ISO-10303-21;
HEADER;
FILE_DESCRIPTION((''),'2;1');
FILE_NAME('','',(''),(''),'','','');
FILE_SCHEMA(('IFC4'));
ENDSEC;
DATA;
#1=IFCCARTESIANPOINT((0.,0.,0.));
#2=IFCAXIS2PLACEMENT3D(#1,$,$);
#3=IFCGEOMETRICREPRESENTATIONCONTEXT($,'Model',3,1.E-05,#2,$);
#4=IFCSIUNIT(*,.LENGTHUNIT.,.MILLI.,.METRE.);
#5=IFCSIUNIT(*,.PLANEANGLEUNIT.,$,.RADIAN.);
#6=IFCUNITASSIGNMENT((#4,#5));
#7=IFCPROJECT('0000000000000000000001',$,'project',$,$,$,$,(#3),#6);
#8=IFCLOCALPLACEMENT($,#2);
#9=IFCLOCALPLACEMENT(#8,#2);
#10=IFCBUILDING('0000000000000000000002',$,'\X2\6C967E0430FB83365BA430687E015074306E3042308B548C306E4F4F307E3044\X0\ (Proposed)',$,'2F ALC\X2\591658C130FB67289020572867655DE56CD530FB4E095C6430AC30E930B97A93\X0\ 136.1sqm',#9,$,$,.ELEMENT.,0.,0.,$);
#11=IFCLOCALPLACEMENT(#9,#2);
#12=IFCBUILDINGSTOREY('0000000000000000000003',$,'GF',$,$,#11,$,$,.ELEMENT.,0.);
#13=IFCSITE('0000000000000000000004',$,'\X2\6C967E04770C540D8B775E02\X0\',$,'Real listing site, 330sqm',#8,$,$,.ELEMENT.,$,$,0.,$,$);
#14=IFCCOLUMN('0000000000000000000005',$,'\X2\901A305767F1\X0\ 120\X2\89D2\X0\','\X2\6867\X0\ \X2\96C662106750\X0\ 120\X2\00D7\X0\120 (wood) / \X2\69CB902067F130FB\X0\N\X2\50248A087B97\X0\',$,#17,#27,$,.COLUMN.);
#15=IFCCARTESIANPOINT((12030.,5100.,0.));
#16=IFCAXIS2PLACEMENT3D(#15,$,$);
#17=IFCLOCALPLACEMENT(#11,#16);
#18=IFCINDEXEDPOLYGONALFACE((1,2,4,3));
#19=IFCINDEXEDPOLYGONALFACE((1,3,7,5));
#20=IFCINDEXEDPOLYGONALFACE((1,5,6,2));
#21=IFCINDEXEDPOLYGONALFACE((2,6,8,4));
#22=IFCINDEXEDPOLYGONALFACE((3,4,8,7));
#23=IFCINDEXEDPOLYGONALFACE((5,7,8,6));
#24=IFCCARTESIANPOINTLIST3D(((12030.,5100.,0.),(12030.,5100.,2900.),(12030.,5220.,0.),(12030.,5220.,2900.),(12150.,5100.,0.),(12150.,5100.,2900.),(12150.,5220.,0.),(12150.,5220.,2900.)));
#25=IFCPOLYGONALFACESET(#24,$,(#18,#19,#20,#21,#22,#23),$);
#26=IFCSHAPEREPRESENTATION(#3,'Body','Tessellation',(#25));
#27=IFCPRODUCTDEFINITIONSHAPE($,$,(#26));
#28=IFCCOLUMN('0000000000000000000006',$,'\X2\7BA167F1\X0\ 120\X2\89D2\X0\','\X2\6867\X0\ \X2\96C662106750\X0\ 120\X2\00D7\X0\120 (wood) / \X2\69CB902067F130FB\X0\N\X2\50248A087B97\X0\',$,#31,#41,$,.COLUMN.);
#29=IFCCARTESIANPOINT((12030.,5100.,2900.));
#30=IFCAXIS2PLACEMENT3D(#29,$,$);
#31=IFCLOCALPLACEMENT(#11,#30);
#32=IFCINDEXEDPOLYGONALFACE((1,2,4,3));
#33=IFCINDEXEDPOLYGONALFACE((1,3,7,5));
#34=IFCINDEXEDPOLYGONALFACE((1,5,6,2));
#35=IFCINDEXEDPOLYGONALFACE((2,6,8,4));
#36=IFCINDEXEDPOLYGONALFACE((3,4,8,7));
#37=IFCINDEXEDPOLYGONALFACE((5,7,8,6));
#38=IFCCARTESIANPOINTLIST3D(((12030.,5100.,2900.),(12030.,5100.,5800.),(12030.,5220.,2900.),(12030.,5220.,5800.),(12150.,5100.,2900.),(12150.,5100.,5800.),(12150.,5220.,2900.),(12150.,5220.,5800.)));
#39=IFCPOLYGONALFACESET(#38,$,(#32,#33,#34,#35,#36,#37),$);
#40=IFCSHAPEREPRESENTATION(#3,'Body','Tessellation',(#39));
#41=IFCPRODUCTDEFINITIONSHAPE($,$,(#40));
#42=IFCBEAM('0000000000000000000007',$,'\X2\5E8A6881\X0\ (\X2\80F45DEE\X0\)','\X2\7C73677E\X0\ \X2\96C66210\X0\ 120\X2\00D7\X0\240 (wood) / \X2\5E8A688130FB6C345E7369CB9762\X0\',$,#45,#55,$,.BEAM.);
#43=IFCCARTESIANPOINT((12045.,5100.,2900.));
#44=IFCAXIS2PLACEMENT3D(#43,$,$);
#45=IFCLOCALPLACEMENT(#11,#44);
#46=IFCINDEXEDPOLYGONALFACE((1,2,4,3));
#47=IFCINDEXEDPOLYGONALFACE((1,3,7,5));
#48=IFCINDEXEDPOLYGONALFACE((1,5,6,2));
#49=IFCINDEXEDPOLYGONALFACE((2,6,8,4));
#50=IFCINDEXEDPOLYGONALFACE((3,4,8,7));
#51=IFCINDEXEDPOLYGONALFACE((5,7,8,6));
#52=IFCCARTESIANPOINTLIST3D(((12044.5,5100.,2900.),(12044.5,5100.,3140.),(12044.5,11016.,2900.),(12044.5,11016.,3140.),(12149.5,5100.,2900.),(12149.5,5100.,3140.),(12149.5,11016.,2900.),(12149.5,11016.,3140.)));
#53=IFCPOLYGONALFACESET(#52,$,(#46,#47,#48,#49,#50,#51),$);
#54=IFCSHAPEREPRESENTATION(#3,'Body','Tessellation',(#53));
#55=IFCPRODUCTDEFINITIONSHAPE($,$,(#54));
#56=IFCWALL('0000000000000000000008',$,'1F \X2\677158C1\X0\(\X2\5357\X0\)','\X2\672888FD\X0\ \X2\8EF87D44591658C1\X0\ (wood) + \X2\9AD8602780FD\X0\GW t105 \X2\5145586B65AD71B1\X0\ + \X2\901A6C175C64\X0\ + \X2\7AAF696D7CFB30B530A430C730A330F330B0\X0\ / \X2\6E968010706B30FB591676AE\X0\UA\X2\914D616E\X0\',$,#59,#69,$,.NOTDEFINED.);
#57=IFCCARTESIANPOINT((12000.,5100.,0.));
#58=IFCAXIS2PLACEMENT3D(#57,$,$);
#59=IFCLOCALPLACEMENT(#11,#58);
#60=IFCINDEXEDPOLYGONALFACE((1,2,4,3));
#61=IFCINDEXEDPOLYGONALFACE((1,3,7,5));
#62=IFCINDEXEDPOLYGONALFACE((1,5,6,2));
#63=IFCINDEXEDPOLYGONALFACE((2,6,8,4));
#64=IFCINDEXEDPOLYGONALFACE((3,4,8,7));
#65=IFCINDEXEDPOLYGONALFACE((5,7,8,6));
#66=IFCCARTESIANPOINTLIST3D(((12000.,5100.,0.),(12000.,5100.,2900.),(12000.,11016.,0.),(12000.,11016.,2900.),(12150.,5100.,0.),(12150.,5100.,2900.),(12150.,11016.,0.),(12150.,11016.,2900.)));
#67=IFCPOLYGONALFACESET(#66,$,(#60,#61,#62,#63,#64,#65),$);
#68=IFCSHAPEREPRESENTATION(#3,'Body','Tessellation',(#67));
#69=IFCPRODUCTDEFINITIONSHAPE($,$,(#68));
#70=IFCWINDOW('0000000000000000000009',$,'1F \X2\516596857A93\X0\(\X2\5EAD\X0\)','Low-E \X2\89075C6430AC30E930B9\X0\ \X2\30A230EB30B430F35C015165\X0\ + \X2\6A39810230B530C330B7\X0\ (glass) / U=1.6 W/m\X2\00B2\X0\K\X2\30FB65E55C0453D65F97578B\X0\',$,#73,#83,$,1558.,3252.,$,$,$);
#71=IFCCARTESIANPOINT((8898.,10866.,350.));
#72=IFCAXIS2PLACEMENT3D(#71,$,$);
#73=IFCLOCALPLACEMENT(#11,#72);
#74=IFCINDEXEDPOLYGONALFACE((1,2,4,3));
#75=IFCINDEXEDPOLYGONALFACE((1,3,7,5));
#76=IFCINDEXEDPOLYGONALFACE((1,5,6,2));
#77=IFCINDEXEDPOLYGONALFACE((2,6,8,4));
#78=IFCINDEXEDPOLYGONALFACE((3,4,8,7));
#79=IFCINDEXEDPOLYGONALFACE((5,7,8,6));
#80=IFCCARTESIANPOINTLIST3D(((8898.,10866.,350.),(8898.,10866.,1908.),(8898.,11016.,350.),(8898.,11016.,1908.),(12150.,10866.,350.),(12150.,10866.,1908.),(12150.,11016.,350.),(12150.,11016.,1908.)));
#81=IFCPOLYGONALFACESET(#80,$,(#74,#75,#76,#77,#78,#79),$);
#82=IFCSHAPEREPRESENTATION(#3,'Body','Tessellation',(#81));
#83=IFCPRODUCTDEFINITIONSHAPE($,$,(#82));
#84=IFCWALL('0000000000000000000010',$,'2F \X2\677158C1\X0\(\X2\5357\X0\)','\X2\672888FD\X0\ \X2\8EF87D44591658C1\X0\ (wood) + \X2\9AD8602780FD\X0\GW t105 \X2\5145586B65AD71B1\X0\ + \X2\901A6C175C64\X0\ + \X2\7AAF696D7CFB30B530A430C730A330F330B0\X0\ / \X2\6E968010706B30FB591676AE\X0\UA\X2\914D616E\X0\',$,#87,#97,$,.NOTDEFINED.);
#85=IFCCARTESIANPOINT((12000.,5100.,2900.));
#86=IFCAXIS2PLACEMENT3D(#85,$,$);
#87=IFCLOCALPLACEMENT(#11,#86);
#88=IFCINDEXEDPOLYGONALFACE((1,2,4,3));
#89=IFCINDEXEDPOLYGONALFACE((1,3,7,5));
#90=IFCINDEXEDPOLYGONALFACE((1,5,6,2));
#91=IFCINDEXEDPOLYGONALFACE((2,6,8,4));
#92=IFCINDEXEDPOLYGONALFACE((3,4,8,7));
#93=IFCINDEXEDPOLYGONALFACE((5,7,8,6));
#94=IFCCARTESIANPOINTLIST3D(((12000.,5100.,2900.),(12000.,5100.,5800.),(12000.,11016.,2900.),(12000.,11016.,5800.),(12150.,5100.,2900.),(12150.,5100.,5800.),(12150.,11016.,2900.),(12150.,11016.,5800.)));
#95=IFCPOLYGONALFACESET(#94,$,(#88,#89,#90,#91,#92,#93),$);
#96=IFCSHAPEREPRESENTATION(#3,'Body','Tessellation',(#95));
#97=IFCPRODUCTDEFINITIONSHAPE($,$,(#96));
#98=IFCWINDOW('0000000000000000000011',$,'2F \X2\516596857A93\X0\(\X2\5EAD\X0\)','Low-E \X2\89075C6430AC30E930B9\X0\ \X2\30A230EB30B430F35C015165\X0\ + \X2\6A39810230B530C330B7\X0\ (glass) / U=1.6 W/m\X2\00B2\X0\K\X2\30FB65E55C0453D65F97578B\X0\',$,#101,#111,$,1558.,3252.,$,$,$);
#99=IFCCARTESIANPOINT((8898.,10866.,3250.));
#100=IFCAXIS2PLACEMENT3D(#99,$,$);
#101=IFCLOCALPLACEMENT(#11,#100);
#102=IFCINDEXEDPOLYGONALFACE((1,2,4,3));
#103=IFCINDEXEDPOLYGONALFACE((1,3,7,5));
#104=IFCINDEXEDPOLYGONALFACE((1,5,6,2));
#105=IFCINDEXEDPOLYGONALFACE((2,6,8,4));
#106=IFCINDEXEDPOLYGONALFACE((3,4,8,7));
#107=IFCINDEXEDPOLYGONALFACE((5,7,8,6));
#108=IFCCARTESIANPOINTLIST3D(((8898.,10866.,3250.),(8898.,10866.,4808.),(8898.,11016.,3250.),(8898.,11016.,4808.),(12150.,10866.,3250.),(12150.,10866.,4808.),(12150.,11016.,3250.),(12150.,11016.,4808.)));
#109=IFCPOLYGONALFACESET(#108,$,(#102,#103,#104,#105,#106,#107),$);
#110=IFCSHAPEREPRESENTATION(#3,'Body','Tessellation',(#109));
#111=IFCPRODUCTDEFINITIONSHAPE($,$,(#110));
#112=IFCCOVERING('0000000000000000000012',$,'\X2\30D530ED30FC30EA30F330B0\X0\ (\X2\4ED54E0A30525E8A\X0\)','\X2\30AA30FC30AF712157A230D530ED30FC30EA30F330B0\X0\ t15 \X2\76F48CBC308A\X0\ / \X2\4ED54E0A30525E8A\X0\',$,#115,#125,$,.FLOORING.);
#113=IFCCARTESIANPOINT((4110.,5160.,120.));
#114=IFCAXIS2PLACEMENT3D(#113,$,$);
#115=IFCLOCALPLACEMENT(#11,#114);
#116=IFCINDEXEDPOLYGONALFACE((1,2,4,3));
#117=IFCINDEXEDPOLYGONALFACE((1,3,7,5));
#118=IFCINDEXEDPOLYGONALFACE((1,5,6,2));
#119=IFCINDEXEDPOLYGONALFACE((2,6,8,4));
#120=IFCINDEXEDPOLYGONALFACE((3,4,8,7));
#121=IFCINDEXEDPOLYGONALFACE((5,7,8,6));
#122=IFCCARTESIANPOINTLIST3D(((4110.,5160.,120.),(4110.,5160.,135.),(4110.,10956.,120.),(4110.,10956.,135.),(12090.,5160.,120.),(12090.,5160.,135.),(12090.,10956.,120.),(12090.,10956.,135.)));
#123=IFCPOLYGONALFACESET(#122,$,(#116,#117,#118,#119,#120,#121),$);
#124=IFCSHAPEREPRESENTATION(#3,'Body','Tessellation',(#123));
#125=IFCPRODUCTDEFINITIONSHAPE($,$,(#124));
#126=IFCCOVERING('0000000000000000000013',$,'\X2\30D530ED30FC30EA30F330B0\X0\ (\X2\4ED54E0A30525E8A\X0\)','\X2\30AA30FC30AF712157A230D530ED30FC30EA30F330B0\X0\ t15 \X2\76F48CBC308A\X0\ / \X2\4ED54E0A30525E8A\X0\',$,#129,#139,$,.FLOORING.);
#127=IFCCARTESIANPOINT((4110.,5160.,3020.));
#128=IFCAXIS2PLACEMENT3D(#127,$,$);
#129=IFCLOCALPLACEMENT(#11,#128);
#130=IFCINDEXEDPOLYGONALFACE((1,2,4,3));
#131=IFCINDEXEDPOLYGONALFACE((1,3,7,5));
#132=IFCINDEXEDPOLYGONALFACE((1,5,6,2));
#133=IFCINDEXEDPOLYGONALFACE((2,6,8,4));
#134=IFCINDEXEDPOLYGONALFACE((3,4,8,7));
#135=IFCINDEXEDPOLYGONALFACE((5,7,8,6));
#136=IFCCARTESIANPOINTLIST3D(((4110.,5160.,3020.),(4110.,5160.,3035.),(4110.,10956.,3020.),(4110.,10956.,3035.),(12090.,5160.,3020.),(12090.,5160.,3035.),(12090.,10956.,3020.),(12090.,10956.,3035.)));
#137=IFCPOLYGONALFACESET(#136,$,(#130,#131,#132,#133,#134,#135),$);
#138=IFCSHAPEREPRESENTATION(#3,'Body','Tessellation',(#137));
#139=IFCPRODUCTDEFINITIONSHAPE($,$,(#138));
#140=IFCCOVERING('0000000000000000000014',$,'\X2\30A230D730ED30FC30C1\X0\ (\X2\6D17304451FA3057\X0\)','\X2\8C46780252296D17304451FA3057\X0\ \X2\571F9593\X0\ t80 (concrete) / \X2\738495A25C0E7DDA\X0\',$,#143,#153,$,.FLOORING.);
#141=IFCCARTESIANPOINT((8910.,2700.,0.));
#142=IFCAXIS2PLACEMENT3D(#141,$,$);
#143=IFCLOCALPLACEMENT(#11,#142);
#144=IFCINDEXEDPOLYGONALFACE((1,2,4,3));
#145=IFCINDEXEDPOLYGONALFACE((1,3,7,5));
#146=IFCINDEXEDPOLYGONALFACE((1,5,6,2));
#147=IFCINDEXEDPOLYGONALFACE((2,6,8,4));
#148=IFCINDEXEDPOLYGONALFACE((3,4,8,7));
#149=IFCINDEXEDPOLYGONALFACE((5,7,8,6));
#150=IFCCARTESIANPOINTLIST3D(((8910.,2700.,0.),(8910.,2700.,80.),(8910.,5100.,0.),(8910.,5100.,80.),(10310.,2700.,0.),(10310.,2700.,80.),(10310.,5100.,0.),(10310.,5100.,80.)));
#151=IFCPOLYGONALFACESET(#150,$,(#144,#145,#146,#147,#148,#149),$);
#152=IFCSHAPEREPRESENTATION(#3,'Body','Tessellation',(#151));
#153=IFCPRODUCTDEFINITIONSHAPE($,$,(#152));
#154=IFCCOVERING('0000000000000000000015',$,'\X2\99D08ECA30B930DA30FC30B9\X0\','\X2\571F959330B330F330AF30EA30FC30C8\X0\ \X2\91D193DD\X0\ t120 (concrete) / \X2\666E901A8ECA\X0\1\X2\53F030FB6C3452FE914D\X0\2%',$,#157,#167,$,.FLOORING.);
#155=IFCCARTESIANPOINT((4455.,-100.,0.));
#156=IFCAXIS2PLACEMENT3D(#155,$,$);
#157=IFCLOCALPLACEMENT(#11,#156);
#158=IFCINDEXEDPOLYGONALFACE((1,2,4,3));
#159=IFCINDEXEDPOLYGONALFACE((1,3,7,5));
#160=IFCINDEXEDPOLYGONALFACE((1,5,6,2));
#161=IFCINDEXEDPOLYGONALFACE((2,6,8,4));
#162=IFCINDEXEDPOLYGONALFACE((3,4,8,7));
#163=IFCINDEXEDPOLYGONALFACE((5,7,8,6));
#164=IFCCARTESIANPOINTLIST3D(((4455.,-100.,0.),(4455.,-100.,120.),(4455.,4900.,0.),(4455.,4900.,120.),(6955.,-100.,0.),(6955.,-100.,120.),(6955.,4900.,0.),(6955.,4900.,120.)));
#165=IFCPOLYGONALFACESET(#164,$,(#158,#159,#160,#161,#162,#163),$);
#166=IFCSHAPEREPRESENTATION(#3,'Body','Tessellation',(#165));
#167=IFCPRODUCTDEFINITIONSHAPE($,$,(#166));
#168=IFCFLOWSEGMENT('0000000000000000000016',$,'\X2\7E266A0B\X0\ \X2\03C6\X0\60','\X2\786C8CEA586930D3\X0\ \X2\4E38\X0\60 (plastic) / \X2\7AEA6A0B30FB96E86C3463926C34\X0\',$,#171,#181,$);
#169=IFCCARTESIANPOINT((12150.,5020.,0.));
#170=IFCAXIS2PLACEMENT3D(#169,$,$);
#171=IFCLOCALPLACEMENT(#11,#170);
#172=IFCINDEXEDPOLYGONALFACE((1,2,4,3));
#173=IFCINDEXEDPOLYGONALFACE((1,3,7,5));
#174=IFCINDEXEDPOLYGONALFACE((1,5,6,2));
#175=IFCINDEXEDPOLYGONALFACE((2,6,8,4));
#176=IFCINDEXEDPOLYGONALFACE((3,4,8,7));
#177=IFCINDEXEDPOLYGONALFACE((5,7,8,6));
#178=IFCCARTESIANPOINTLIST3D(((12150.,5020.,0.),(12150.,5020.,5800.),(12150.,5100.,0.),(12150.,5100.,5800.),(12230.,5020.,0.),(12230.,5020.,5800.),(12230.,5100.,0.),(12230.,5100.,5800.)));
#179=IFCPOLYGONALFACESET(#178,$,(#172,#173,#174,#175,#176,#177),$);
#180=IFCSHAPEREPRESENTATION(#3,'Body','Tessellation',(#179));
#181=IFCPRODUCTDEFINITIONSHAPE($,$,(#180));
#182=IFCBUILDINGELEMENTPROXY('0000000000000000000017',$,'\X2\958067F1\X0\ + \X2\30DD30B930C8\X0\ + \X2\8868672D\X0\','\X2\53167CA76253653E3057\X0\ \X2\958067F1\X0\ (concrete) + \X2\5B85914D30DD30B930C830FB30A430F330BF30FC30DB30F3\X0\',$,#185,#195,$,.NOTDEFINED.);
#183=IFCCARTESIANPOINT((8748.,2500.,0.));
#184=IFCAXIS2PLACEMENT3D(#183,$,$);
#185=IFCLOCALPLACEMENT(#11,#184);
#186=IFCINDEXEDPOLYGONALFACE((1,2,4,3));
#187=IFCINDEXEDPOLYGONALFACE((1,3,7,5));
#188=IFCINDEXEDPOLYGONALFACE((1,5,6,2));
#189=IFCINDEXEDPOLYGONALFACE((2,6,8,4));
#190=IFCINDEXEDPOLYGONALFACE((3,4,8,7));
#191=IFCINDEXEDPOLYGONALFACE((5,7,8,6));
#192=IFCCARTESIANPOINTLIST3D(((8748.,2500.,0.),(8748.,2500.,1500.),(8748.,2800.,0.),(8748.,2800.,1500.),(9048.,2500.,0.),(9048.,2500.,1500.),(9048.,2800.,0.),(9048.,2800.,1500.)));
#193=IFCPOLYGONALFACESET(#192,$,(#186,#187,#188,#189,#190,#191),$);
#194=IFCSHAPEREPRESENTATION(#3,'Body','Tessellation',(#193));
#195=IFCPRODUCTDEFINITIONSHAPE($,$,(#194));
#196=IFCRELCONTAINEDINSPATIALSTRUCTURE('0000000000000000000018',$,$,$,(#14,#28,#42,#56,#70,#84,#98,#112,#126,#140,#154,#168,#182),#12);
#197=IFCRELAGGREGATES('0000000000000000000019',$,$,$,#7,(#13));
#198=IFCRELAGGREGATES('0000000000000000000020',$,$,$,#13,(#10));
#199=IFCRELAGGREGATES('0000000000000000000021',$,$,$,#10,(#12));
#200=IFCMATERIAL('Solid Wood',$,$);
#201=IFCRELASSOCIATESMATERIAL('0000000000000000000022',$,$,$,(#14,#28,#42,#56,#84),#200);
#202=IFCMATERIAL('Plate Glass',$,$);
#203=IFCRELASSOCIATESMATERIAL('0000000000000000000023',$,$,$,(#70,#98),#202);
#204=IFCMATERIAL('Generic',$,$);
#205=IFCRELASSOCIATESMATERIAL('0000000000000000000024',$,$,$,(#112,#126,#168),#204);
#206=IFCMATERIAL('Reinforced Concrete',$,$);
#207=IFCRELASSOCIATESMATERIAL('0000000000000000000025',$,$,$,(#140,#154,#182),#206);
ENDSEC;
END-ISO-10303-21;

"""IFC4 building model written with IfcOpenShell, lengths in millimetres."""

from ifc_helpers import new_model, si_unit, frame, frame_2d, origin, place, context, project, spatial, rectangle, extrude, material, element, fill, save


model = new_model("IFC4")

# Units and contexts
model_context = context("Model", 3, precision=1e-05, world=origin())
ifc_project = project(units=[si_unit("LENGTHUNIT", "METRE", prefix="MILLI"), si_unit("PLANEANGLEUNIT", "RADIAN")], contexts=[model_context])

# Site, building, storey
site_placement = place(None, origin())
site = spatial("IfcSite", under=ifc_project, at=site_placement, Name="沖縄県名護市", ObjectType="Real listing site, 330sqm", CompositionType="ELEMENT", RefElevation=0.0)
building_placement = place(site_placement, origin())
building = spatial("IfcBuilding", under=site, at=building_placement, Name="沖縄・茶室と縁側のある和の住まい (Proposed)", ObjectType="2F ALC外壁・木造在来工法・三層ガラス窓 136.1sqm", CompositionType="ELEMENT", ElevationOfRefHeight=0.0, ElevationOfTerrain=0.0)
storey_placement = place(building_placement, origin())
storey = spatial("IfcBuildingStorey", under=building, at=storey_placement, Name="GF", CompositionType="ELEMENT", Elevation=0.0)

# Columns
ifc_material_1 = material(Name="Solid Wood")
column_1_placement = place(storey_placement, frame((12030.0, 5100.0, 0.0)))
element("IfcColumn", 1, at=column_1_placement, inside=storey, material=ifc_material_1, Name="通し柱 120角", Description="桧 集成材 120×120 (wood) / 構造柱・N値計算", PredefinedType="COLUMN", context=model_context, shape_type="SweptSolid", body=[
    extrude(rectangle(XDim=120.0, YDim=120.0, at=frame_2d((60.0, 60.0))), frame((12030.0, 5100.0, 0.0)), (0.0, 0.0, 1.0), 2900.0),
])
column_2_placement = place(storey_placement, frame((12030.0, 5100.0, 2900.0)))
element("IfcColumn", 2, at=column_2_placement, inside=storey, material=ifc_material_1, Name="管柱 120角", Description="桧 集成材 120×120 (wood) / 構造柱・N値計算", PredefinedType="COLUMN", context=model_context, shape_type="SweptSolid", body=[
    extrude(rectangle(XDim=120.0, YDim=120.0, at=frame_2d((60.0, 60.0))), frame((12030.0, 5100.0, 2900.0)), (0.0, 0.0, 1.0), 2900.0),
])

# Beam
beam_1_placement = place(storey_placement, frame((12045.0, 5100.0, 2900.0)))
element("IfcBeam", 3, at=beam_1_placement, inside=storey, material=ifc_material_1, Name="床梁 (胴差)", Description="米松 集成 120×240 (wood) / 床梁・水平構面", PredefinedType="BEAM", context=model_context, shape_type="SweptSolid", body=[
    extrude(rectangle(XDim=105.0, YDim=5916.0, at=frame_2d((52.0, 2958.0))), frame((12045.0, 5100.0, 2900.0)), (0.0, 0.0, 1.0), 240.0),
])

# Wall, opening, window
wall_1_placement = place(storey_placement, frame((12000.0, 5100.0, 0.0)))
wall_1 = element("IfcWall", 4, at=wall_1_placement, inside=storey, material=ifc_material_1, Name="1F 東壁(南)", Description="木製 軸組外壁 (wood) + 高性能GW t105 充填断熱 + 通気層 + 窯業系サイディング / 準耐火・外皮UA配慮", PredefinedType="NOTDEFINED", context=model_context, shape_type="SweptSolid", body=[
    extrude(rectangle(XDim=150.0, YDim=5916.0, at=frame_2d((75.0, 2958.0))), frame((12000.0, 5100.0, 0.0)), (0.0, 0.0, 1.0), 2900.0),
])
opening_1_placement = place(storey_placement, frame((8898.0, 10866.0, 350.0)))
opening_1 = element("IfcOpeningElement", 5, at=opening_1_placement, cuts=wall_1, PredefinedType="NOTDEFINED", context=model_context, shape_type="SweptSolid", body=[
    extrude(rectangle(XDim=3252.0, YDim=150.0, at=frame_2d((1626.0, 75.0))), frame((8898.0, 10866.0, 350.0)), (0.0, 0.0, 1.0), 1558.0),
])
ifc_material_2 = material(Name="Plate Glass")
window_1_placement = place(storey_placement, frame((8898.0, 10866.0, 350.0)))
window_1 = element("IfcWindow", 6, at=window_1_placement, inside=storey, material=ifc_material_2, Name="1F 入隅窓(庭)", Description="Low-E 複層ガラス アルゴン封入 + 樹脂サッシ (glass) / U=1.6 W/m²K・日射取得型", OverallHeight=1558.0, OverallWidth=3252.0, context=model_context, shape_type="SweptSolid", body=[
    extrude(rectangle(XDim=3252.0, YDim=150.0, at=frame_2d((1626.0, 75.0))), frame((8898.0, 10866.0, 350.0)), (0.0, 0.0, 1.0), 1558.0),
])
fill(opening_1, window_1)

# Wall, opening, window
wall_2_placement = place(storey_placement, frame((12000.0, 5100.0, 2900.0)))
wall_2 = element("IfcWall", 7, at=wall_2_placement, inside=storey, material=ifc_material_1, Name="2F 東壁(南)", Description="木製 軸組外壁 (wood) + 高性能GW t105 充填断熱 + 通気層 + 窯業系サイディング / 準耐火・外皮UA配慮", PredefinedType="NOTDEFINED", context=model_context, shape_type="SweptSolid", body=[
    extrude(rectangle(XDim=150.0, YDim=5916.0, at=frame_2d((75.0, 2958.0))), frame((12000.0, 5100.0, 2900.0)), (0.0, 0.0, 1.0), 2900.0),
])
opening_2_placement = place(storey_placement, frame((8898.0, 10866.0, 3250.0)))
opening_2 = element("IfcOpeningElement", 8, at=opening_2_placement, cuts=wall_2, PredefinedType="NOTDEFINED", context=model_context, shape_type="SweptSolid", body=[
    extrude(rectangle(XDim=3252.0, YDim=150.0, at=frame_2d((1626.0, 75.0))), frame((8898.0, 10866.0, 3250.0)), (0.0, 0.0, 1.0), 1558.0),
])
window_2_placement = place(storey_placement, frame((8898.0, 10866.0, 3250.0)))
window_2 = element("IfcWindow", 9, at=window_2_placement, inside=storey, material=ifc_material_2, Name="2F 入隅窓(庭)", Description="Low-E 複層ガラス アルゴン封入 + 樹脂サッシ (glass) / U=1.6 W/m²K・日射取得型", OverallHeight=1558.0, OverallWidth=3252.0, context=model_context, shape_type="SweptSolid", body=[
    extrude(rectangle(XDim=3252.0, YDim=150.0, at=frame_2d((1626.0, 75.0))), frame((8898.0, 10866.0, 3250.0)), (0.0, 0.0, 1.0), 1558.0),
])
fill(opening_2, window_2)

# Coverings
ifc_material_3 = material(Name="Generic")
covering_1_placement = place(storey_placement, frame((4110.0, 5160.0, 120.0)))
element("IfcCovering", 10, at=covering_1_placement, inside=storey, material=ifc_material_3, Name="フローリング (仕上げ床)", Description="オーク無垢フローリング t15 直貼り / 仕上げ床", PredefinedType="FLOORING", context=model_context, shape_type="SweptSolid", body=[
    extrude(rectangle(XDim=7980.0, YDim=5796.0, at=frame_2d((3990.0, 2898.0))), frame((4110.0, 5160.0, 120.0)), (0.0, 0.0, 1.0), 15.0),
])
covering_2_placement = place(storey_placement, frame((4110.0, 5160.0, 3020.0)))
element("IfcCovering", 11, at=covering_2_placement, inside=storey, material=ifc_material_3, Name="フローリング (仕上げ床)", Description="オーク無垢フローリング t15 直貼り / 仕上げ床", PredefinedType="FLOORING", context=model_context, shape_type="SweptSolid", body=[
    extrude(rectangle(XDim=7980.0, YDim=5796.0, at=frame_2d((3990.0, 2898.0))), frame((4110.0, 5160.0, 3020.0)), (0.0, 0.0, 1.0), 15.0),
])
ifc_material_4 = material(Name="Reinforced Concrete")
covering_3_placement = place(storey_placement, frame((8910.0, 2700.0, 0.0)))
element("IfcCovering", 12, at=covering_3_placement, inside=storey, material=ifc_material_4, Name="アプローチ (洗い出し)", Description="豆砂利洗い出し 土間 t80 (concrete) / 玄関導線", PredefinedType="FLOORING", context=model_context, shape_type="SweptSolid", body=[
    extrude(rectangle(XDim=1400.0, YDim=2400.0, at=frame_2d((700.0, 1200.0))), frame((8910.0, 2700.0, 0.0)), (0.0, 0.0, 1.0), 80.0),
])
covering_4_placement = place(storey_placement, frame((4455.0, -100.0, 0.0)))
element("IfcCovering", 13, at=covering_4_placement, inside=storey, material=ifc_material_4, Name="駐車スペース", Description="土間コンクリート 金鏝 t120 (concrete) / 普通車1台・水勾配2%", PredefinedType="FLOORING", context=model_context, shape_type="SweptSolid", body=[
    extrude(rectangle(XDim=2500.0, YDim=5000.0, at=frame_2d((1250.0, 2500.0))), frame((4455.0, -100.0, 0.0)), (0.0, 0.0, 1.0), 120.0),
])

# Flow segment
flow_segment_placement = place(storey_placement, frame((12150.0, 5020.0, 0.0)))
element("IfcFlowSegment", 14, at=flow_segment_placement, inside=storey, material=ifc_material_3, Name="縦樋 φ60", Description="硬質塩ビ 丸60 (plastic) / 竪樋・雨水排水", context=model_context, shape_type="SweptSolid", body=[
    extrude(rectangle(XDim=80.0, YDim=80.0, at=frame_2d((40.0, 40.0))), frame((12150.0, 5020.0, 0.0)), (0.0, 0.0, 1.0), 5800.0),
])

# Building element proxy
proxy_placement = place(storey_placement, frame((8748.0, 2500.0, 0.0)))
element("IfcBuildingElementProxy", 15, at=proxy_placement, inside=storey, material=ifc_material_4, Name="門柱 + ポスト + 表札", Description="化粧打放し 門柱 (concrete) + 宅配ポスト・インターホン", PredefinedType="NOTDEFINED", context=model_context, shape_type="SweptSolid", body=[
    extrude(rectangle(XDim=300.0, YDim=300.0, at=frame_2d((150.0, 150.0))), frame((8748.0, 2500.0, 0.0)), (0.0, 0.0, 1.0), 1500.0),
])

save(model, "model.ifc")
